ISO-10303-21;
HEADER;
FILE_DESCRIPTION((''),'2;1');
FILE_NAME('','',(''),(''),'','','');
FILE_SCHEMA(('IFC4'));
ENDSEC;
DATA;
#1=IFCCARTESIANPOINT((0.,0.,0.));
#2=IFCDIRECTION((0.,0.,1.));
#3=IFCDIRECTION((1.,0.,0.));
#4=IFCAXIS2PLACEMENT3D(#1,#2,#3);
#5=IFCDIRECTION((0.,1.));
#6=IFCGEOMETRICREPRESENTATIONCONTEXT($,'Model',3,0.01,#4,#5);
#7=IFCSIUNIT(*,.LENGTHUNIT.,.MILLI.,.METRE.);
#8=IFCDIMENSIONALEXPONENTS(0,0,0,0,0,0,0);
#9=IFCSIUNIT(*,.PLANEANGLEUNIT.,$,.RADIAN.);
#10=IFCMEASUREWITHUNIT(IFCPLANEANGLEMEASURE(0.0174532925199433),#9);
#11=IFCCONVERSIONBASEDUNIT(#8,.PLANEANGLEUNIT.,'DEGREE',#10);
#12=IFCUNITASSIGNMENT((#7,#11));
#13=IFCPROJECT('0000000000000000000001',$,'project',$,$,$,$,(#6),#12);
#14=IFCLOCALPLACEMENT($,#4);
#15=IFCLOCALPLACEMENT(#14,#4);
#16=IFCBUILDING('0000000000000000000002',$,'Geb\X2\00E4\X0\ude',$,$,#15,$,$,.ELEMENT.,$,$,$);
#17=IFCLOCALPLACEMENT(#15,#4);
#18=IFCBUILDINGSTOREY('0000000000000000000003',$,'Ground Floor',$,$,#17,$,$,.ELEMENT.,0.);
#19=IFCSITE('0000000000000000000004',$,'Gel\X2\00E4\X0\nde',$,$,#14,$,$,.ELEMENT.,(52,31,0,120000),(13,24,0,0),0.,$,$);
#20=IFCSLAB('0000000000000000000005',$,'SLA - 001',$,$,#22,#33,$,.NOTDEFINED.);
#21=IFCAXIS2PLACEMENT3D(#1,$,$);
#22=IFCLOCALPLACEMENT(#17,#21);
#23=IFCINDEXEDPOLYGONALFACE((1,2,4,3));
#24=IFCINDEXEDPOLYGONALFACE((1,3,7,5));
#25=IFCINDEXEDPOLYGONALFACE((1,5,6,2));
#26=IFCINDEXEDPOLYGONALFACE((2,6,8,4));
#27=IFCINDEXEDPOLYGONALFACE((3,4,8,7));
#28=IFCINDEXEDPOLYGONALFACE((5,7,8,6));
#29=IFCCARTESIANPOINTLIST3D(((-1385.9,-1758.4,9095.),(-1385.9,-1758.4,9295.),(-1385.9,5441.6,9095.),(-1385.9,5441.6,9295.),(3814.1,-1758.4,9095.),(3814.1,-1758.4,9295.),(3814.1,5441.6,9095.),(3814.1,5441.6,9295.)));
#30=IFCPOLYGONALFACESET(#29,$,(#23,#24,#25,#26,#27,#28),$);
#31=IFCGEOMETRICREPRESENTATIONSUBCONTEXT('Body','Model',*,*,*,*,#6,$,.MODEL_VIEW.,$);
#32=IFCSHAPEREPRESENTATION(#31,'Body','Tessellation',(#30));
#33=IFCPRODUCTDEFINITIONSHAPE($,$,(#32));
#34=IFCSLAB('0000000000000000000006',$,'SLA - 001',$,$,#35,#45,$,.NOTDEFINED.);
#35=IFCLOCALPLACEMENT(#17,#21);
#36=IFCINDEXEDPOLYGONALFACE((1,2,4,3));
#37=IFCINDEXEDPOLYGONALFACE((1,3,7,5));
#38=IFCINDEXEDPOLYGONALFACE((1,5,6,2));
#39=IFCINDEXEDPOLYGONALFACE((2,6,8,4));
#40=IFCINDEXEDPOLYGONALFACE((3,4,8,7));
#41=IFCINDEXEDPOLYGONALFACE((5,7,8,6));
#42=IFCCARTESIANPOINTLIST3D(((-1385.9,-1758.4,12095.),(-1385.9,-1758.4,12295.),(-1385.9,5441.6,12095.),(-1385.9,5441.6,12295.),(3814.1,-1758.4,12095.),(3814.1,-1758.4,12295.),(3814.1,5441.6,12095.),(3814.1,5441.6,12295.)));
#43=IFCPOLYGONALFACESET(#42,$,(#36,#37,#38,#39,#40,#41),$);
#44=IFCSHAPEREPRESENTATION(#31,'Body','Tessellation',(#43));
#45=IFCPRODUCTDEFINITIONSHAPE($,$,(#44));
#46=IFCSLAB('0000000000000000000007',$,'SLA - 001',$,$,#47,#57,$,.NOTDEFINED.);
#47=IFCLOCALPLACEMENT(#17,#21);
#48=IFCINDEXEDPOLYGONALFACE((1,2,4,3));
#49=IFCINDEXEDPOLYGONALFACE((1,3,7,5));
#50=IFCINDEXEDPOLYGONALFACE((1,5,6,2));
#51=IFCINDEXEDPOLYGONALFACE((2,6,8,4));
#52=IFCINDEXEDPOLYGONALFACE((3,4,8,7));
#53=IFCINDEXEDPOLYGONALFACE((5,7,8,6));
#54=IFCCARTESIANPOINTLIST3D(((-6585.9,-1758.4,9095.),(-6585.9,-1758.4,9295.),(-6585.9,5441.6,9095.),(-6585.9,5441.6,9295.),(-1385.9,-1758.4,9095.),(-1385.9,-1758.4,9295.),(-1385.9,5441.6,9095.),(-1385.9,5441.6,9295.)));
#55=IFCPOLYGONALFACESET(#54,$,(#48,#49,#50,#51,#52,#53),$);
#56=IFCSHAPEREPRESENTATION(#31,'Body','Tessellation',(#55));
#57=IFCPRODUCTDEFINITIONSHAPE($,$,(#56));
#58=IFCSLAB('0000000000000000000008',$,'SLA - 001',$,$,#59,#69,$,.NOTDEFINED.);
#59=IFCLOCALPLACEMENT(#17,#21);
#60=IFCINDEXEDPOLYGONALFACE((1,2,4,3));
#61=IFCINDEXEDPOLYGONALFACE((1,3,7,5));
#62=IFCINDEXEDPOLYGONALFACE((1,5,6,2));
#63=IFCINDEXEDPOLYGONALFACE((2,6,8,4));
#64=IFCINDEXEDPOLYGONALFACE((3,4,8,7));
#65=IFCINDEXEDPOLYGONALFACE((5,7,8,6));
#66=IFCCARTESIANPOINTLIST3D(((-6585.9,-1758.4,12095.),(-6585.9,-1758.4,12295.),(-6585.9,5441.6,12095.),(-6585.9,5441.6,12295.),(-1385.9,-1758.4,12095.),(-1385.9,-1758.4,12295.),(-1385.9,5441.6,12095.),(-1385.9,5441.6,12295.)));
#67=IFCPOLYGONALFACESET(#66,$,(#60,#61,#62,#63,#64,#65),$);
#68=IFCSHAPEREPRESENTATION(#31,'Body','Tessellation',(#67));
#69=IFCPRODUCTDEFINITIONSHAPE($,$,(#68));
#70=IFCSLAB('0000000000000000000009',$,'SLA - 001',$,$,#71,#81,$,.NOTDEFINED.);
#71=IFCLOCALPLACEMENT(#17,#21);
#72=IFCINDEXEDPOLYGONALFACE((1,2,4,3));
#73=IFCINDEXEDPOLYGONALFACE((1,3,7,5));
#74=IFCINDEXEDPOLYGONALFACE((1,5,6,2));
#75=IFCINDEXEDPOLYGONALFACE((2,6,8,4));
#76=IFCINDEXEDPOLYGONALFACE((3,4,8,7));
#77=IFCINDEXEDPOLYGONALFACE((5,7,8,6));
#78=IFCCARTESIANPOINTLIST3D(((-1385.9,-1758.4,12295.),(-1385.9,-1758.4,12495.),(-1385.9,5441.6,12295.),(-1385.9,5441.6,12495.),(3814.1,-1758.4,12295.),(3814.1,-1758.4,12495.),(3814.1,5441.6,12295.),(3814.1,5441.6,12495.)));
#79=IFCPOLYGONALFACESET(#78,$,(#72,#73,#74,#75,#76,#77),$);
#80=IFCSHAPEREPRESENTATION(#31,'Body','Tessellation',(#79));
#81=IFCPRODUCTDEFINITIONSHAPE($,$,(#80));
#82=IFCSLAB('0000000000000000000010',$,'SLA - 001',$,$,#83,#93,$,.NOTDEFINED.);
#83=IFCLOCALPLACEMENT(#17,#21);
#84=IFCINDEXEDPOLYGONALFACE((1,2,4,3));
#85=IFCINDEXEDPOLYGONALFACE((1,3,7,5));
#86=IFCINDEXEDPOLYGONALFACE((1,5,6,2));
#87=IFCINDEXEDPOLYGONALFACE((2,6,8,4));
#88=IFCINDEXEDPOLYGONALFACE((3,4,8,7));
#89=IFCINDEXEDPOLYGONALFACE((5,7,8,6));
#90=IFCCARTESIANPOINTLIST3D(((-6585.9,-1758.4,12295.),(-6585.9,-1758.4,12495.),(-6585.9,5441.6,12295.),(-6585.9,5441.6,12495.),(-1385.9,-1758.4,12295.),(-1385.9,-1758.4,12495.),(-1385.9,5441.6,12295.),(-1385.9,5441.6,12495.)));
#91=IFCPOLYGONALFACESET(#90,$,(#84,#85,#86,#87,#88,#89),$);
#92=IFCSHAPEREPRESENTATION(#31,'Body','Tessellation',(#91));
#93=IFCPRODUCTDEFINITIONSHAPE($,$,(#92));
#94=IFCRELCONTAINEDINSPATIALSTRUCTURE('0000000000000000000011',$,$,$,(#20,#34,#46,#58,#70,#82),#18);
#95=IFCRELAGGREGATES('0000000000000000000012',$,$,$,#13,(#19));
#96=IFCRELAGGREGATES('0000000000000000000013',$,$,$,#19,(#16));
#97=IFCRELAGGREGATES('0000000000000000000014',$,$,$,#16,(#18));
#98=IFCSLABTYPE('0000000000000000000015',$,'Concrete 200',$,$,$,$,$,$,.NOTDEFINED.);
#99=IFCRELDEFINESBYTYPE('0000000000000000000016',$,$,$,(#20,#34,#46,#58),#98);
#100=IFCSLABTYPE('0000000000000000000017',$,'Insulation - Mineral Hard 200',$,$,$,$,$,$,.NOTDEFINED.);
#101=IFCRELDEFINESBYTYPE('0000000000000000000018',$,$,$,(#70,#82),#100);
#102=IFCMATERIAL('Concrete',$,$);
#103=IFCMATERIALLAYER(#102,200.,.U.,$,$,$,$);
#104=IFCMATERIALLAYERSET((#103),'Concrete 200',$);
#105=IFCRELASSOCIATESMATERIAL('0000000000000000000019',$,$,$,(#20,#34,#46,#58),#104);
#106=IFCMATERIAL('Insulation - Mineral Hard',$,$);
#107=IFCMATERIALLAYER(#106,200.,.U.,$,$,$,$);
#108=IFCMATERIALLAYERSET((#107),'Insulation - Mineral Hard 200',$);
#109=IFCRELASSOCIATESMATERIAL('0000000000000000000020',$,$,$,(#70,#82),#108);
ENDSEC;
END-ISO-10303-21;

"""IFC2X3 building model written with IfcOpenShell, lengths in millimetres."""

from ifc_helpers import new_model, entity, si_unit, converted_unit, direction, frame, origin_with_axes, place, context, subcontext, project, spatial, polyline, outline, extrude, material, layer, layer_set, layer_usage, type_object, element, save


model = new_model("IFC2X3")

# Units and contexts
model_context = context("Model", 3, precision=0.01, world=origin_with_axes(), true_north=direction((0.0, 1.0)))
body_context = subcontext(model_context, "Body", "Model", "MODEL_VIEW")
ifc_project = project(units=[si_unit("LENGTHUNIT", "METRE", prefix="MILLI"), converted_unit("PLANEANGLEUNIT", "DEGREE", entity("IfcPlaneAngleMeasure", 0.0174532925199433), si_unit("PLANEANGLEUNIT", "RADIAN"), dimensions=[0, 0, 0, 0, 0, 0, 0])], contexts=[model_context])

# Site, building, storey
site_placement = place(None, origin_with_axes())
site = spatial("IfcSite", under=ifc_project, at=site_placement, Name="Gelände", CompositionType="ELEMENT", RefLatitude=(52, 31, 0, 120000), RefLongitude=(13, 24, 0, 0), RefElevation=0.0)
building_placement = place(site_placement, origin_with_axes())
building = spatial("IfcBuilding", under=site, at=building_placement, Name="Gebäude", CompositionType="ELEMENT")
storey_placement = place(building_placement, origin_with_axes())
storey = spatial("IfcBuildingStorey", under=building, at=storey_placement, Name="Ground Floor", CompositionType="ELEMENT", Elevation=0.0)

# Slabs
ifc_material_1 = material(Name="Concrete")
ifc_layer_1 = layer(ifc_material_1, 200.0, ventilated="UNKNOWN")
ifc_layer_set_1 = layer_set([ifc_layer_1], Name="Concrete 200")
ifc_layer_usage_1 = layer_usage(ifc_layer_set_1, "AXIS3", "NEGATIVE", 200.0)
slab_type_1 = type_object("IfcSlabType", Name="Concrete 200", PredefinedType="NOTDEFINED")
slab_1_placement = place(storey_placement, frame((-1385.9, -1758.4, 9295.0), z_axis=(0.0, 0.0, 1.0), x_axis=(1.0, 0.0, 0.0)))
element("IfcSlab", 1, at=slab_1_placement, inside=storey, type_object=slab_type_1, material=ifc_layer_usage_1, Name="SLA - 001", PredefinedType="NOTDEFINED", context=body_context, shape_type="SweptSolid", body=[
    extrude(outline(polyline([(0.0, 0.0), (5200.0, 0.0), (5200.0, 7200.0), (0.0, 7200.0), (0.0, 0.0)])), frame((0.0, 0.0, -200.0), z_axis=(0.0, 0.0, 1.0), x_axis=(1.0, 0.0, 0.0)), (0.0, 0.0, 1.0), 200.0),
])
ifc_layer_usage_2 = layer_usage(ifc_layer_set_1, "AXIS3", "NEGATIVE", 200.0)
slab_2_placement = place(storey_placement, frame((-1385.9, -1758.4, 12295.0), z_axis=(0.0, 0.0, 1.0), x_axis=(1.0, 0.0, 0.0)))
element("IfcSlab", 2, at=slab_2_placement, inside=storey, type_object=slab_type_1, material=ifc_layer_usage_2, Name="SLA - 001", PredefinedType="NOTDEFINED", context=body_context, shape_type="SweptSolid", body=[
    extrude(outline(polyline([(0.0, 0.0), (5200.0, 0.0), (5200.0, 7200.0), (0.0, 7200.0), (0.0, 0.0)])), frame((0.0, 0.0, -200.0), z_axis=(0.0, 0.0, 1.0), x_axis=(1.0, 0.0, 0.0)), (0.0, 0.0, 1.0), 200.0),
])
ifc_layer_usage_3 = layer_usage(ifc_layer_set_1, "AXIS3", "NEGATIVE", 200.0)
slab_3_placement = place(storey_placement, frame((-6585.9, -1758.4, 9295.0), z_axis=(0.0, 0.0, 1.0), x_axis=(1.0, 0.0, 0.0)))
element("IfcSlab", 3, at=slab_3_placement, inside=storey, type_object=slab_type_1, material=ifc_layer_usage_3, Name="SLA - 001", PredefinedType="NOTDEFINED", context=body_context, shape_type="SweptSolid", body=[
    extrude(outline(polyline([(0.0, 0.0), (5200.0, 0.0), (5200.0, 7200.0), (0.0, 7200.0), (0.0, 0.0)])), frame((0.0, 0.0, -200.0), z_axis=(0.0, 0.0, 1.0), x_axis=(1.0, 0.0, 0.0)), (0.0, 0.0, 1.0), 200.0),
])
ifc_layer_usage_4 = layer_usage(ifc_layer_set_1, "AXIS3", "NEGATIVE", 200.0)
slab_4_placement = place(storey_placement, frame((-6585.9, -1758.4, 12295.0), z_axis=(0.0, 0.0, 1.0), x_axis=(1.0, 0.0, 0.0)))
element("IfcSlab", 4, at=slab_4_placement, inside=storey, type_object=slab_type_1, material=ifc_layer_usage_4, Name="SLA - 001", PredefinedType="NOTDEFINED", context=body_context, shape_type="SweptSolid", body=[
    extrude(outline(polyline([(0.0, 0.0), (5200.0, 0.0), (5200.0, 7200.0), (0.0, 7200.0), (0.0, 0.0)])), frame((0.0, 0.0, -200.0), z_axis=(0.0, 0.0, 1.0), x_axis=(1.0, 0.0, 0.0)), (0.0, 0.0, 1.0), 200.0),
])
ifc_material_2 = material(Name="Insulation - Mineral Hard")
ifc_layer_2 = layer(ifc_material_2, 200.0, ventilated="UNKNOWN")
ifc_layer_set_2 = layer_set([ifc_layer_2], Name="Insulation - Mineral Hard 200")
ifc_layer_usage_5 = layer_usage(ifc_layer_set_2, "AXIS3", "NEGATIVE", 200.0)
slab_type_2 = type_object("IfcSlabType", Name="Insulation - Mineral Hard 200", PredefinedType="NOTDEFINED")
slab_5_placement = place(storey_placement, frame((-1385.9, -1758.4, 12495.0), z_axis=(0.0, 0.0, 1.0), x_axis=(1.0, 0.0, 0.0)))
element("IfcSlab", 5, at=slab_5_placement, inside=storey, type_object=slab_type_2, material=ifc_layer_usage_5, Name="SLA - 001", PredefinedType="NOTDEFINED", context=body_context, shape_type="SweptSolid", body=[
    extrude(outline(polyline([(0.0, 0.0), (5200.0, 0.0), (5200.0, 7200.0), (0.0, 7200.0), (0.0, 0.0)])), frame((0.0, 0.0, -200.0), z_axis=(0.0, 0.0, 1.0), x_axis=(1.0, 0.0, 0.0)), (0.0, 0.0, 1.0), 200.0),
])
ifc_layer_usage_6 = layer_usage(ifc_layer_set_2, "AXIS3", "NEGATIVE", 200.0)
slab_6_placement = place(storey_placement, frame((-6585.9, -1758.4, 12495.0), z_axis=(0.0, 0.0, 1.0), x_axis=(1.0, 0.0, 0.0)))
element("IfcSlab", 6, at=slab_6_placement, inside=storey, type_object=slab_type_2, material=ifc_layer_usage_6, Name="SLA - 001", PredefinedType="NOTDEFINED", context=body_context, shape_type="SweptSolid", body=[
    extrude(outline(polyline([(0.0, 0.0), (5200.0, 0.0), (5200.0, 7200.0), (0.0, 7200.0), (0.0, 0.0)])), frame((0.0, 0.0, -200.0), z_axis=(0.0, 0.0, 1.0), x_axis=(1.0, 0.0, 0.0)), (0.0, 0.0, 1.0), 200.0),
])

save(model, "model.ifc")
